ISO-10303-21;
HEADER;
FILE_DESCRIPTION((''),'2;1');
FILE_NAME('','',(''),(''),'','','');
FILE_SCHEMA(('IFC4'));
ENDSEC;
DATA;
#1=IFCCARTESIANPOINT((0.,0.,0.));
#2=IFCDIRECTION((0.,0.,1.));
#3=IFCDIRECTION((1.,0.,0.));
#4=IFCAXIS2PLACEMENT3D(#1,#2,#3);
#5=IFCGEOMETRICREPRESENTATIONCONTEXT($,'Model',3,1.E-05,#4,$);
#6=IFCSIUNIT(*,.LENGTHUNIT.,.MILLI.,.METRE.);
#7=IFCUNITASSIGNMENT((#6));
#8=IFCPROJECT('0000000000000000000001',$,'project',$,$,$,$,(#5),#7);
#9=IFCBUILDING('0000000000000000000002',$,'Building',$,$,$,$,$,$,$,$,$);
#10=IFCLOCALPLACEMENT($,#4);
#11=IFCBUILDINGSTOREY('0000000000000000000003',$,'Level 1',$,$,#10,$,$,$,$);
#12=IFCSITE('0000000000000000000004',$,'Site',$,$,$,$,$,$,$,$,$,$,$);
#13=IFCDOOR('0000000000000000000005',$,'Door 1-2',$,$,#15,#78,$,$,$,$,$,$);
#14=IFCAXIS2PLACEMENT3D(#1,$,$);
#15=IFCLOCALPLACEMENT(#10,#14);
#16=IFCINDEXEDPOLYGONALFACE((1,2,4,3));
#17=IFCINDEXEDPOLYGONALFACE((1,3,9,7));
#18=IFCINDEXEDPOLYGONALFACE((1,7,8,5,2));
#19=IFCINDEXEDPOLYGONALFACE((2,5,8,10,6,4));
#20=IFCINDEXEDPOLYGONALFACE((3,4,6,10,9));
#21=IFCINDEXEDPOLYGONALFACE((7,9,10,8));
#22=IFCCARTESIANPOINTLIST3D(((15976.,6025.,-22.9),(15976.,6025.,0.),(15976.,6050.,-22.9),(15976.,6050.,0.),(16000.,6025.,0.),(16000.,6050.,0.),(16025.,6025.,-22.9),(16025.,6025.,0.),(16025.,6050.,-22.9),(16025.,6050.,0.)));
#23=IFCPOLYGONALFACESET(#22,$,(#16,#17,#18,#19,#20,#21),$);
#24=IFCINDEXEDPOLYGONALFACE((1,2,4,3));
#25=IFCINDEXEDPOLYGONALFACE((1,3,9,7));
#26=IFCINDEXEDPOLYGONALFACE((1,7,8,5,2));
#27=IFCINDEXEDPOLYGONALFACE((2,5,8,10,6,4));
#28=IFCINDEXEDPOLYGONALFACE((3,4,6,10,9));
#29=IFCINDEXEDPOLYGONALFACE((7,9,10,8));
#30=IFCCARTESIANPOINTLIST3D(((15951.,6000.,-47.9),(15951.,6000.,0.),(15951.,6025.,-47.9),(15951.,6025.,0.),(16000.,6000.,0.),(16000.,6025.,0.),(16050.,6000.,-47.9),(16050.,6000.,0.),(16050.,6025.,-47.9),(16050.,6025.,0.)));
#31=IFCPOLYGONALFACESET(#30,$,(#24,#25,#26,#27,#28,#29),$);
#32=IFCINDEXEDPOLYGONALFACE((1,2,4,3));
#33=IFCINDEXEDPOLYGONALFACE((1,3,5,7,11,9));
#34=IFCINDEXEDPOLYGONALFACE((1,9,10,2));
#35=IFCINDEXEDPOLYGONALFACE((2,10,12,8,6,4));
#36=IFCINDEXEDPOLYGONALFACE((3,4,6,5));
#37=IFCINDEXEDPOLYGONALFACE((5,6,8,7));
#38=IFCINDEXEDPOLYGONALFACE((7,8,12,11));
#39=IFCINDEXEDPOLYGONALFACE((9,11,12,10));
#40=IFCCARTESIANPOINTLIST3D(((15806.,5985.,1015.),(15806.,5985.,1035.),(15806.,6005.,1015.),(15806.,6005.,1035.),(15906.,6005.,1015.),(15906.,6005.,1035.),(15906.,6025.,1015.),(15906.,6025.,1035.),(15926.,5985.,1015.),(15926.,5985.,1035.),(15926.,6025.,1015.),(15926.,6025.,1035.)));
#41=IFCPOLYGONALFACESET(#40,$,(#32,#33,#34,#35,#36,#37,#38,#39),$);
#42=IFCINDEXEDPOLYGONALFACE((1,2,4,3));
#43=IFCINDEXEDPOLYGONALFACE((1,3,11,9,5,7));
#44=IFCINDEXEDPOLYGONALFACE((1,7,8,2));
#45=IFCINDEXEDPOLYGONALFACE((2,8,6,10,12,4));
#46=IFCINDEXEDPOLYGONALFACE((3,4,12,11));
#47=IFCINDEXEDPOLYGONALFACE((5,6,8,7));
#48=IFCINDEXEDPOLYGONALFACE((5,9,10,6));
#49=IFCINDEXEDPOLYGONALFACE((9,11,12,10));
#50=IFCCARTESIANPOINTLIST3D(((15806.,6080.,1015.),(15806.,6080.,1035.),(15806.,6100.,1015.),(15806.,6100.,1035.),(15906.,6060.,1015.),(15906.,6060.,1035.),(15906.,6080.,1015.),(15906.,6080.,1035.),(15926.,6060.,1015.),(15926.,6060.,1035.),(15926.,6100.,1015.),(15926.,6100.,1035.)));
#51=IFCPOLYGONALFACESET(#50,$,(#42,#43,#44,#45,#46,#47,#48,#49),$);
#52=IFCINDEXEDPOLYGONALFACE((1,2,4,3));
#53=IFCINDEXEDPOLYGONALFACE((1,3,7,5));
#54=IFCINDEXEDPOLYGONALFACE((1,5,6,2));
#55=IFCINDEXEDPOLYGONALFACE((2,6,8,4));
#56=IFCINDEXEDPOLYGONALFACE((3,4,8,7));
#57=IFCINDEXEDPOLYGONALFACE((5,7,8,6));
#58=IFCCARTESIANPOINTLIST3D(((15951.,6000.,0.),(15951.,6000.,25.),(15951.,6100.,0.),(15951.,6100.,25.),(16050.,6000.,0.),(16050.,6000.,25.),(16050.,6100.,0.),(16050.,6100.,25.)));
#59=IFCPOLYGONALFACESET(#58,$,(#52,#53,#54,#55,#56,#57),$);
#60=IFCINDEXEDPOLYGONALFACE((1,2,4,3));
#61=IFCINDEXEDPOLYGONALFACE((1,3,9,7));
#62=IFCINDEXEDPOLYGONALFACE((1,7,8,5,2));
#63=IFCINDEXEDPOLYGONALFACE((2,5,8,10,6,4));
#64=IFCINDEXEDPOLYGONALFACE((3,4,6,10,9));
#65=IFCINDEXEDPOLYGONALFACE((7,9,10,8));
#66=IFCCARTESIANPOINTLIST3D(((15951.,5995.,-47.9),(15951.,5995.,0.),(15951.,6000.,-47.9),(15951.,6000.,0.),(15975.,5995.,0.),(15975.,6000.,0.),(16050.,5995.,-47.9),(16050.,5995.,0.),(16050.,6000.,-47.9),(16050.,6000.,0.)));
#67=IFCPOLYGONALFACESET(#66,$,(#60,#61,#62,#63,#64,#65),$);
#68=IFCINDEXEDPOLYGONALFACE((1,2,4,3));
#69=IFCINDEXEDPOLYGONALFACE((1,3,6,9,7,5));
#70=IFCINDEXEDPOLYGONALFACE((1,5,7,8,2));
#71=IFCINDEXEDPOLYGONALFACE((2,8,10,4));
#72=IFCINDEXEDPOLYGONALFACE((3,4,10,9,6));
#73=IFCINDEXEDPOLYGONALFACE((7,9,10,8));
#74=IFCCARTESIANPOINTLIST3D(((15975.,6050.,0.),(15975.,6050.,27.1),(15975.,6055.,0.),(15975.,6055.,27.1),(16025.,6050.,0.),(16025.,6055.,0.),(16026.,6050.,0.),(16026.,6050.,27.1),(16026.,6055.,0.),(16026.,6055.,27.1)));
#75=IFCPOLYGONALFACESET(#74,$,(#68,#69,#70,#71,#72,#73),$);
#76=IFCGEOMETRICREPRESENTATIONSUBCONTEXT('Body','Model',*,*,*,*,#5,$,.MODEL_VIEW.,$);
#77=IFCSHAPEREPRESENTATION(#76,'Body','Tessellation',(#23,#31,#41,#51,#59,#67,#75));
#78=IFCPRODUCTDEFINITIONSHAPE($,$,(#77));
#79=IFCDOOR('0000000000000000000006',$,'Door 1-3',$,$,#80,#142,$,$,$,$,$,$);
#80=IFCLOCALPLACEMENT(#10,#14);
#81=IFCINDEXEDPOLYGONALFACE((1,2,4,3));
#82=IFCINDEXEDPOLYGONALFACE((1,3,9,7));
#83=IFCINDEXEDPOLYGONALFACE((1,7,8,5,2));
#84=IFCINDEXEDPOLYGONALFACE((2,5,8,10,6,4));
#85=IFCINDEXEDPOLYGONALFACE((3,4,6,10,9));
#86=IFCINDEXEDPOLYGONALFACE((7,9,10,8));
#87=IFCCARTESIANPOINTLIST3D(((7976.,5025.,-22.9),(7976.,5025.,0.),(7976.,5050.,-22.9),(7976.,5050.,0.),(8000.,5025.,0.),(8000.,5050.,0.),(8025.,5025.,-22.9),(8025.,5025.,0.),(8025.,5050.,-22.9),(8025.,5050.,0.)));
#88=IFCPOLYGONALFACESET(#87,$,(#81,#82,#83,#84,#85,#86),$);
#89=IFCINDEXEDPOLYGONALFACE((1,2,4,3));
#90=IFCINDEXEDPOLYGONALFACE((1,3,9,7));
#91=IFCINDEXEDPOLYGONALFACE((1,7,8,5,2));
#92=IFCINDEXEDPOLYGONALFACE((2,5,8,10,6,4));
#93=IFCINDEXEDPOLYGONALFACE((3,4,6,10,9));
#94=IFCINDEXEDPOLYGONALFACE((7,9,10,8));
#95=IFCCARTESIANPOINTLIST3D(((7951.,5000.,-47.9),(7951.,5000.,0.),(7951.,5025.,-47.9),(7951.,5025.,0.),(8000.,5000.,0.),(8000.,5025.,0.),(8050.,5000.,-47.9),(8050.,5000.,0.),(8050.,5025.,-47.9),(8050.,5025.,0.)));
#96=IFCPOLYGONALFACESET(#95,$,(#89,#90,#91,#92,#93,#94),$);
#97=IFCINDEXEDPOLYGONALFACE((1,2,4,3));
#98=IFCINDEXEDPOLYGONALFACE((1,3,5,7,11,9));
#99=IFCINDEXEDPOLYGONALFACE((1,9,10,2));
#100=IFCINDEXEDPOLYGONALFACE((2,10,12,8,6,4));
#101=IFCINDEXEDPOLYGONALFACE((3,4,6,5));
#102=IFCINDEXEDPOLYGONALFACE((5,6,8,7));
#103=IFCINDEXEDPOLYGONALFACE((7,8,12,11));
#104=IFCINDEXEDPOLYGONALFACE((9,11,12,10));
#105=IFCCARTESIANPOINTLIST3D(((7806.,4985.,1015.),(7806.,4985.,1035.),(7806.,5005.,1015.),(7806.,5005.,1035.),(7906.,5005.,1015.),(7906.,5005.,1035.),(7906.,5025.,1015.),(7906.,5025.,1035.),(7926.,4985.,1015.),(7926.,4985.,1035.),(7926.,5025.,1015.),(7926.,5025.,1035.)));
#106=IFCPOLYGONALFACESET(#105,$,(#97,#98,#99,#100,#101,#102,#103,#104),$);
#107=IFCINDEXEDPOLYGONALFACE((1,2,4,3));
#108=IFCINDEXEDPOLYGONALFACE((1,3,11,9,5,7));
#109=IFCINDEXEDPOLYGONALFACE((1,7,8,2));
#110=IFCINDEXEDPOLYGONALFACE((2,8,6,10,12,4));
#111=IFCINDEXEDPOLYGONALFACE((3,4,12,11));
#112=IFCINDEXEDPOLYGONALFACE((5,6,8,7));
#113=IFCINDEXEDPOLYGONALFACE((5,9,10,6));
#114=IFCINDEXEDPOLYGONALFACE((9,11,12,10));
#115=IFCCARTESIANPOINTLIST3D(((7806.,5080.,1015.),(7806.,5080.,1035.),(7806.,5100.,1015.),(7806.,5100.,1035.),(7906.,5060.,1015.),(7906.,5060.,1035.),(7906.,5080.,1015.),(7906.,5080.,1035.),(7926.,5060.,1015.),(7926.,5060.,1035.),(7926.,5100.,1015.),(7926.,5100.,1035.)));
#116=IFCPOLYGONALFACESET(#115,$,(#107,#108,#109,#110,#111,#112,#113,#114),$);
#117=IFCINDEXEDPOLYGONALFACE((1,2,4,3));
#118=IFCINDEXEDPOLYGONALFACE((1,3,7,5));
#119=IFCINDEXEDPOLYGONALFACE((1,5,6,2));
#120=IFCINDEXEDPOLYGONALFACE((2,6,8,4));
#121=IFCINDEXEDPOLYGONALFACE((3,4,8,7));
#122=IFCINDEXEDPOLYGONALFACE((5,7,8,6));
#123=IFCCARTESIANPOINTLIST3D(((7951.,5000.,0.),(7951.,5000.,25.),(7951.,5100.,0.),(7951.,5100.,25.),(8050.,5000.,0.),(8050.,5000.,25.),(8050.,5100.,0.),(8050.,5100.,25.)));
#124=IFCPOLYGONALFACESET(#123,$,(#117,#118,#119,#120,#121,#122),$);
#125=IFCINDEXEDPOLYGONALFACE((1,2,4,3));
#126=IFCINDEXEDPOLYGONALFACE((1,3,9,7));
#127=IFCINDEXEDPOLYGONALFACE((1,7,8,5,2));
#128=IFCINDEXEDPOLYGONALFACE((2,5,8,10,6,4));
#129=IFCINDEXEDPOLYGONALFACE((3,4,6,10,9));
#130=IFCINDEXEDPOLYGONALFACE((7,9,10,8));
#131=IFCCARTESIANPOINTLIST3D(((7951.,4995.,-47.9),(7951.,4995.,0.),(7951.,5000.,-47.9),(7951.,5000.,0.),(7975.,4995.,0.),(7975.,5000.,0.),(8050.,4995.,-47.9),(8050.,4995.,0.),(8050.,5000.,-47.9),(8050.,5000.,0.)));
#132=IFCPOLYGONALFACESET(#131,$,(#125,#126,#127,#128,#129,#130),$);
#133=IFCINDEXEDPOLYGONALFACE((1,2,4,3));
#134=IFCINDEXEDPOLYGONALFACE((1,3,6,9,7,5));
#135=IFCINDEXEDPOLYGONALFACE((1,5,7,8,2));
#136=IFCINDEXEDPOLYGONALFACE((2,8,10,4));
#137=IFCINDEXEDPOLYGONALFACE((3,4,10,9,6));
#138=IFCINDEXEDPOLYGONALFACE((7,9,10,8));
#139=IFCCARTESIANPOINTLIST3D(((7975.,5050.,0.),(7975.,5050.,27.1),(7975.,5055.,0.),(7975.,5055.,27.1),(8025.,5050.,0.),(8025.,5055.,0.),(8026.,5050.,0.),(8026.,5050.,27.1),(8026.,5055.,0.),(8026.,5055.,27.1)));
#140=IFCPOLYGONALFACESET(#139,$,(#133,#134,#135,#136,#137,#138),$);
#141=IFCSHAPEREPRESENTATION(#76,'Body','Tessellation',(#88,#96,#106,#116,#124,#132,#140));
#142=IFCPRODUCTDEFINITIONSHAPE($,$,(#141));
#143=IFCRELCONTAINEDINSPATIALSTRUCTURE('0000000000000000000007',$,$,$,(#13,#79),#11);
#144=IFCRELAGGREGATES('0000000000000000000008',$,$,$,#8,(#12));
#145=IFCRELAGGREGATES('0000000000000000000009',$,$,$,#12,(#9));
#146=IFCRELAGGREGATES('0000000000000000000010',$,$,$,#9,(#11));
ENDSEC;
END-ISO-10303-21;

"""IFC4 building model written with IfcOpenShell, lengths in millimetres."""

from ifc_helpers import new_model, si_unit, frame, origin_with_axes, place, context, subcontext, project, spatial, line, indexed_curve, outline, extrude, element, save


model = new_model("IFC4")

# Units and contexts
model_context = context("Model", 3, precision=1e-05, world=origin_with_axes())
body_context = subcontext(model_context, "Body", "Model", "MODEL_VIEW")
ifc_project = project(units=[si_unit("LENGTHUNIT", "METRE", prefix="MILLI")], contexts=[model_context])

# Site, building, storey
site = spatial("IfcSite", under=ifc_project, Name="Site")
building = spatial("IfcBuilding", under=site, Name="Building")
storey_placement = place(None, origin_with_axes())
storey = spatial("IfcBuildingStorey", under=building, at=storey_placement, Name="Level 1")

# Doors
door_1_placement = place(storey_placement, frame((16000.0, 6000.0, 0.0), z_axis=(0.0, 0.0, 1.0), x_axis=(1.0, 0.0, 0.0)))
element("IfcDoor", 1, at=door_1_placement, inside=storey, Name="Door 1-2", context=body_context, shape_type="SweptSolid", body=[
    extrude(outline(indexed_curve([(0.0, 0.0), (0.0, 2.1), (1.0, 2.1), (1.0, 0.0), (-24.0, 0.0), (-24.0, -22.9), (25.0, -22.9), (25.0, 0.0)], segments=[line(1, 2, 3, 4, 5, 6, 7, 8, 1)])), frame((0.0, 25.0, 0.0), z_axis=(0.0, -1.0, 0.0), x_axis=(1.0, 0.0, 0.0)), (0.0, 0.0, -1.0), 25.0),
    extrude(outline(indexed_curve([(0.0, 0.0), (0.0, 2.1), (1.0, 2.1), (1.0, 0.0), (-49.0, 0.0), (-49.0, -47.9), (50.0, -47.9), (50.0, 0.0)], segments=[line(1, 2, 3, 4, 5, 6, 7, 8, 1)])), frame((0.0, 0.0, 0.0), z_axis=(0.0, -1.0, 0.0), x_axis=(1.0, 0.0, 0.0)), (0.0, 0.0, -1.0), 25.0),
    extrude(outline(indexed_curve([(0.0, 0.0), (-49.0, 0.0), (-49.0, 35.0), (0.0, 35.0)], segments=[line(1, 2, 3, 4, 1)])), frame((25.0, 25.0, 25.0), z_axis=(0.0, 0.0, 1.0), x_axis=(1.0, 0.0, 0.0)), (0.0, 0.0, 1.0), -47.9),
    extrude(outline(indexed_curve([(0.0, 0.0), (0.0, -40.0), (-120.0, -40.0), (-120.0, -20.0), (-20.0, -20.0), (-20.0, 0.0)], segments=[line(1, 2, 3, 4, 5, 6, 1)])), frame((-74.0, 25.0, 1015.0), z_axis=(0.0, 0.0, 1.0), x_axis=(1.0, 0.0, 0.0)), (0.0, 0.0, 1.0), 20.0),
    extrude(outline(indexed_curve([(0.0, 0.0), (0.0, 40.0), (-120.0, 40.0), (-120.0, 20.0), (-20.0, 20.0), (-20.0, 0.0)], segments=[line(1, 2, 3, 4, 5, 6, 1)])), frame((-74.0, 60.0, 1015.0), z_axis=(0.0, 0.0, 1.0), x_axis=(1.0, 0.0, 0.0)), (0.0, 0.0, 1.0), 20.0),
    extrude(outline(indexed_curve([(0.0, 0.0), (-99.0, 0.0), (-99.0, 100.0), (0.0, 100.0)], segments=[line(1, 2, 3, 4, 1)])), frame((50.0, 0.0, 0.0), z_axis=(0.0, 0.0, 1.0), x_axis=(1.0, 0.0, 0.0)), (0.0, 0.0, 1.0), 25.0),
    extrude(outline(indexed_curve([(0.0, 0.0), (0.0, 27.1), (51.0, 27.1), (51.0, 0.0), (-24.0, 0.0), (-24.0, -47.9), (75.0, -47.9), (75.0, 0.0)], segments=[line(1, 2, 3, 4, 5, 6, 7, 8, 1)])), frame((-25.0, -5.0, 0.0), z_axis=(0.0, -1.0, 0.0), x_axis=(1.0, 0.0, 0.0)), (0.0, 0.0, -1.0), 5.0),
    extrude(outline(indexed_curve([(0.0, 0.0), (0.0, 27.1), (51.0, 27.1), (51.0, 0.0), (1.0, 0.0), (1.0, -22.9), (50.0, -22.9), (50.0, 0.0)], segments=[line(1, 2, 3, 4, 5, 6, 7, 8, 1)])), frame((-25.0, 50.0, 0.0), z_axis=(0.0, -1.0, 0.0), x_axis=(1.0, 0.0, 0.0)), (0.0, 0.0, -1.0), 5.0),
])
door_2_placement = place(storey_placement, frame((8000.0, 5000.0, 0.0), z_axis=(0.0, 0.0, 1.0), x_axis=(1.0, 0.0, 0.0)))
element("IfcDoor", 2, at=door_2_placement, inside=storey, Name="Door 1-3", context=body_context, shape_type="SweptSolid", body=[
    extrude(outline(indexed_curve([(0.0, 0.0), (0.0, 2.1), (1.0, 2.1), (1.0, 0.0), (-24.0, 0.0), (-24.0, -22.9), (25.0, -22.9), (25.0, 0.0)], segments=[line(1, 2, 3, 4, 5, 6, 7, 8, 1)])), frame((0.0, 25.0, 0.0), z_axis=(0.0, -1.0, 0.0), x_axis=(1.0, 0.0, 0.0)), (0.0, 0.0, -1.0), 25.0),
    extrude(outline(indexed_curve([(0.0, 0.0), (0.0, 2.1), (1.0, 2.1), (1.0, 0.0), (-49.0, 0.0), (-49.0, -47.9), (50.0, -47.9), (50.0, 0.0)], segments=[line(1, 2, 3, 4, 5, 6, 7, 8, 1)])), frame((0.0, 0.0, 0.0), z_axis=(0.0, -1.0, 0.0), x_axis=(1.0, 0.0, 0.0)), (0.0, 0.0, -1.0), 25.0),
    extrude(outline(indexed_curve([(0.0, 0.0), (-49.0, 0.0), (-49.0, 35.0), (0.0, 35.0)], segments=[line(1, 2, 3, 4, 1)])), frame((25.0, 25.0, 25.0), z_axis=(0.0, 0.0, 1.0), x_axis=(1.0, 0.0, 0.0)), (0.0, 0.0, 1.0), -47.9),
    extrude(outline(indexed_curve([(0.0, 0.0), (0.0, -40.0), (-120.0, -40.0), (-120.0, -20.0), (-20.0, -20.0), (-20.0, 0.0)], segments=[line(1, 2, 3, 4, 5, 6, 1)])), frame((-74.0, 25.0, 1015.0), z_axis=(0.0, 0.0, 1.0), x_axis=(1.0, 0.0, 0.0)), (0.0, 0.0, 1.0), 20.0),
    extrude(outline(indexed_curve([(0.0, 0.0), (0.0, 40.0), (-120.0, 40.0), (-120.0, 20.0), (-20.0, 20.0), (-20.0, 0.0)], segments=[line(1, 2, 3, 4, 5, 6, 1)])), frame((-74.0, 60.0, 1015.0), z_axis=(0.0, 0.0, 1.0), x_axis=(1.0, 0.0, 0.0)), (0.0, 0.0, 1.0), 20.0),
    extrude(outline(indexed_curve([(0.0, 0.0), (-99.0, 0.0), (-99.0, 100.0), (0.0, 100.0)], segments=[line(1, 2, 3, 4, 1)])), frame((50.0, 0.0, 0.0), z_axis=(0.0, 0.0, 1.0), x_axis=(1.0, 0.0, 0.0)), (0.0, 0.0, 1.0), 25.0),
    extrude(outline(indexed_curve([(0.0, 0.0), (0.0, 27.1), (51.0, 27.1), (51.0, 0.0), (-24.0, 0.0), (-24.0, -47.9), (75.0, -47.9), (75.0, 0.0)], segments=[line(1, 2, 3, 4, 5, 6, 7, 8, 1)])), frame((-25.0, -5.0, 0.0), z_axis=(0.0, -1.0, 0.0), x_axis=(1.0, 0.0, 0.0)), (0.0, 0.0, -1.0), 5.0),
    extrude(outline(indexed_curve([(0.0, 0.0), (0.0, 27.1), (51.0, 27.1), (51.0, 0.0), (1.0, 0.0), (1.0, -22.9), (50.0, -22.9), (50.0, 0.0)], segments=[line(1, 2, 3, 4, 5, 6, 7, 8, 1)])), frame((-25.0, 50.0, 0.0), z_axis=(0.0, -1.0, 0.0), x_axis=(1.0, 0.0, 0.0)), (0.0, 0.0, -1.0), 5.0),
])

save(model, "model.ifc")
